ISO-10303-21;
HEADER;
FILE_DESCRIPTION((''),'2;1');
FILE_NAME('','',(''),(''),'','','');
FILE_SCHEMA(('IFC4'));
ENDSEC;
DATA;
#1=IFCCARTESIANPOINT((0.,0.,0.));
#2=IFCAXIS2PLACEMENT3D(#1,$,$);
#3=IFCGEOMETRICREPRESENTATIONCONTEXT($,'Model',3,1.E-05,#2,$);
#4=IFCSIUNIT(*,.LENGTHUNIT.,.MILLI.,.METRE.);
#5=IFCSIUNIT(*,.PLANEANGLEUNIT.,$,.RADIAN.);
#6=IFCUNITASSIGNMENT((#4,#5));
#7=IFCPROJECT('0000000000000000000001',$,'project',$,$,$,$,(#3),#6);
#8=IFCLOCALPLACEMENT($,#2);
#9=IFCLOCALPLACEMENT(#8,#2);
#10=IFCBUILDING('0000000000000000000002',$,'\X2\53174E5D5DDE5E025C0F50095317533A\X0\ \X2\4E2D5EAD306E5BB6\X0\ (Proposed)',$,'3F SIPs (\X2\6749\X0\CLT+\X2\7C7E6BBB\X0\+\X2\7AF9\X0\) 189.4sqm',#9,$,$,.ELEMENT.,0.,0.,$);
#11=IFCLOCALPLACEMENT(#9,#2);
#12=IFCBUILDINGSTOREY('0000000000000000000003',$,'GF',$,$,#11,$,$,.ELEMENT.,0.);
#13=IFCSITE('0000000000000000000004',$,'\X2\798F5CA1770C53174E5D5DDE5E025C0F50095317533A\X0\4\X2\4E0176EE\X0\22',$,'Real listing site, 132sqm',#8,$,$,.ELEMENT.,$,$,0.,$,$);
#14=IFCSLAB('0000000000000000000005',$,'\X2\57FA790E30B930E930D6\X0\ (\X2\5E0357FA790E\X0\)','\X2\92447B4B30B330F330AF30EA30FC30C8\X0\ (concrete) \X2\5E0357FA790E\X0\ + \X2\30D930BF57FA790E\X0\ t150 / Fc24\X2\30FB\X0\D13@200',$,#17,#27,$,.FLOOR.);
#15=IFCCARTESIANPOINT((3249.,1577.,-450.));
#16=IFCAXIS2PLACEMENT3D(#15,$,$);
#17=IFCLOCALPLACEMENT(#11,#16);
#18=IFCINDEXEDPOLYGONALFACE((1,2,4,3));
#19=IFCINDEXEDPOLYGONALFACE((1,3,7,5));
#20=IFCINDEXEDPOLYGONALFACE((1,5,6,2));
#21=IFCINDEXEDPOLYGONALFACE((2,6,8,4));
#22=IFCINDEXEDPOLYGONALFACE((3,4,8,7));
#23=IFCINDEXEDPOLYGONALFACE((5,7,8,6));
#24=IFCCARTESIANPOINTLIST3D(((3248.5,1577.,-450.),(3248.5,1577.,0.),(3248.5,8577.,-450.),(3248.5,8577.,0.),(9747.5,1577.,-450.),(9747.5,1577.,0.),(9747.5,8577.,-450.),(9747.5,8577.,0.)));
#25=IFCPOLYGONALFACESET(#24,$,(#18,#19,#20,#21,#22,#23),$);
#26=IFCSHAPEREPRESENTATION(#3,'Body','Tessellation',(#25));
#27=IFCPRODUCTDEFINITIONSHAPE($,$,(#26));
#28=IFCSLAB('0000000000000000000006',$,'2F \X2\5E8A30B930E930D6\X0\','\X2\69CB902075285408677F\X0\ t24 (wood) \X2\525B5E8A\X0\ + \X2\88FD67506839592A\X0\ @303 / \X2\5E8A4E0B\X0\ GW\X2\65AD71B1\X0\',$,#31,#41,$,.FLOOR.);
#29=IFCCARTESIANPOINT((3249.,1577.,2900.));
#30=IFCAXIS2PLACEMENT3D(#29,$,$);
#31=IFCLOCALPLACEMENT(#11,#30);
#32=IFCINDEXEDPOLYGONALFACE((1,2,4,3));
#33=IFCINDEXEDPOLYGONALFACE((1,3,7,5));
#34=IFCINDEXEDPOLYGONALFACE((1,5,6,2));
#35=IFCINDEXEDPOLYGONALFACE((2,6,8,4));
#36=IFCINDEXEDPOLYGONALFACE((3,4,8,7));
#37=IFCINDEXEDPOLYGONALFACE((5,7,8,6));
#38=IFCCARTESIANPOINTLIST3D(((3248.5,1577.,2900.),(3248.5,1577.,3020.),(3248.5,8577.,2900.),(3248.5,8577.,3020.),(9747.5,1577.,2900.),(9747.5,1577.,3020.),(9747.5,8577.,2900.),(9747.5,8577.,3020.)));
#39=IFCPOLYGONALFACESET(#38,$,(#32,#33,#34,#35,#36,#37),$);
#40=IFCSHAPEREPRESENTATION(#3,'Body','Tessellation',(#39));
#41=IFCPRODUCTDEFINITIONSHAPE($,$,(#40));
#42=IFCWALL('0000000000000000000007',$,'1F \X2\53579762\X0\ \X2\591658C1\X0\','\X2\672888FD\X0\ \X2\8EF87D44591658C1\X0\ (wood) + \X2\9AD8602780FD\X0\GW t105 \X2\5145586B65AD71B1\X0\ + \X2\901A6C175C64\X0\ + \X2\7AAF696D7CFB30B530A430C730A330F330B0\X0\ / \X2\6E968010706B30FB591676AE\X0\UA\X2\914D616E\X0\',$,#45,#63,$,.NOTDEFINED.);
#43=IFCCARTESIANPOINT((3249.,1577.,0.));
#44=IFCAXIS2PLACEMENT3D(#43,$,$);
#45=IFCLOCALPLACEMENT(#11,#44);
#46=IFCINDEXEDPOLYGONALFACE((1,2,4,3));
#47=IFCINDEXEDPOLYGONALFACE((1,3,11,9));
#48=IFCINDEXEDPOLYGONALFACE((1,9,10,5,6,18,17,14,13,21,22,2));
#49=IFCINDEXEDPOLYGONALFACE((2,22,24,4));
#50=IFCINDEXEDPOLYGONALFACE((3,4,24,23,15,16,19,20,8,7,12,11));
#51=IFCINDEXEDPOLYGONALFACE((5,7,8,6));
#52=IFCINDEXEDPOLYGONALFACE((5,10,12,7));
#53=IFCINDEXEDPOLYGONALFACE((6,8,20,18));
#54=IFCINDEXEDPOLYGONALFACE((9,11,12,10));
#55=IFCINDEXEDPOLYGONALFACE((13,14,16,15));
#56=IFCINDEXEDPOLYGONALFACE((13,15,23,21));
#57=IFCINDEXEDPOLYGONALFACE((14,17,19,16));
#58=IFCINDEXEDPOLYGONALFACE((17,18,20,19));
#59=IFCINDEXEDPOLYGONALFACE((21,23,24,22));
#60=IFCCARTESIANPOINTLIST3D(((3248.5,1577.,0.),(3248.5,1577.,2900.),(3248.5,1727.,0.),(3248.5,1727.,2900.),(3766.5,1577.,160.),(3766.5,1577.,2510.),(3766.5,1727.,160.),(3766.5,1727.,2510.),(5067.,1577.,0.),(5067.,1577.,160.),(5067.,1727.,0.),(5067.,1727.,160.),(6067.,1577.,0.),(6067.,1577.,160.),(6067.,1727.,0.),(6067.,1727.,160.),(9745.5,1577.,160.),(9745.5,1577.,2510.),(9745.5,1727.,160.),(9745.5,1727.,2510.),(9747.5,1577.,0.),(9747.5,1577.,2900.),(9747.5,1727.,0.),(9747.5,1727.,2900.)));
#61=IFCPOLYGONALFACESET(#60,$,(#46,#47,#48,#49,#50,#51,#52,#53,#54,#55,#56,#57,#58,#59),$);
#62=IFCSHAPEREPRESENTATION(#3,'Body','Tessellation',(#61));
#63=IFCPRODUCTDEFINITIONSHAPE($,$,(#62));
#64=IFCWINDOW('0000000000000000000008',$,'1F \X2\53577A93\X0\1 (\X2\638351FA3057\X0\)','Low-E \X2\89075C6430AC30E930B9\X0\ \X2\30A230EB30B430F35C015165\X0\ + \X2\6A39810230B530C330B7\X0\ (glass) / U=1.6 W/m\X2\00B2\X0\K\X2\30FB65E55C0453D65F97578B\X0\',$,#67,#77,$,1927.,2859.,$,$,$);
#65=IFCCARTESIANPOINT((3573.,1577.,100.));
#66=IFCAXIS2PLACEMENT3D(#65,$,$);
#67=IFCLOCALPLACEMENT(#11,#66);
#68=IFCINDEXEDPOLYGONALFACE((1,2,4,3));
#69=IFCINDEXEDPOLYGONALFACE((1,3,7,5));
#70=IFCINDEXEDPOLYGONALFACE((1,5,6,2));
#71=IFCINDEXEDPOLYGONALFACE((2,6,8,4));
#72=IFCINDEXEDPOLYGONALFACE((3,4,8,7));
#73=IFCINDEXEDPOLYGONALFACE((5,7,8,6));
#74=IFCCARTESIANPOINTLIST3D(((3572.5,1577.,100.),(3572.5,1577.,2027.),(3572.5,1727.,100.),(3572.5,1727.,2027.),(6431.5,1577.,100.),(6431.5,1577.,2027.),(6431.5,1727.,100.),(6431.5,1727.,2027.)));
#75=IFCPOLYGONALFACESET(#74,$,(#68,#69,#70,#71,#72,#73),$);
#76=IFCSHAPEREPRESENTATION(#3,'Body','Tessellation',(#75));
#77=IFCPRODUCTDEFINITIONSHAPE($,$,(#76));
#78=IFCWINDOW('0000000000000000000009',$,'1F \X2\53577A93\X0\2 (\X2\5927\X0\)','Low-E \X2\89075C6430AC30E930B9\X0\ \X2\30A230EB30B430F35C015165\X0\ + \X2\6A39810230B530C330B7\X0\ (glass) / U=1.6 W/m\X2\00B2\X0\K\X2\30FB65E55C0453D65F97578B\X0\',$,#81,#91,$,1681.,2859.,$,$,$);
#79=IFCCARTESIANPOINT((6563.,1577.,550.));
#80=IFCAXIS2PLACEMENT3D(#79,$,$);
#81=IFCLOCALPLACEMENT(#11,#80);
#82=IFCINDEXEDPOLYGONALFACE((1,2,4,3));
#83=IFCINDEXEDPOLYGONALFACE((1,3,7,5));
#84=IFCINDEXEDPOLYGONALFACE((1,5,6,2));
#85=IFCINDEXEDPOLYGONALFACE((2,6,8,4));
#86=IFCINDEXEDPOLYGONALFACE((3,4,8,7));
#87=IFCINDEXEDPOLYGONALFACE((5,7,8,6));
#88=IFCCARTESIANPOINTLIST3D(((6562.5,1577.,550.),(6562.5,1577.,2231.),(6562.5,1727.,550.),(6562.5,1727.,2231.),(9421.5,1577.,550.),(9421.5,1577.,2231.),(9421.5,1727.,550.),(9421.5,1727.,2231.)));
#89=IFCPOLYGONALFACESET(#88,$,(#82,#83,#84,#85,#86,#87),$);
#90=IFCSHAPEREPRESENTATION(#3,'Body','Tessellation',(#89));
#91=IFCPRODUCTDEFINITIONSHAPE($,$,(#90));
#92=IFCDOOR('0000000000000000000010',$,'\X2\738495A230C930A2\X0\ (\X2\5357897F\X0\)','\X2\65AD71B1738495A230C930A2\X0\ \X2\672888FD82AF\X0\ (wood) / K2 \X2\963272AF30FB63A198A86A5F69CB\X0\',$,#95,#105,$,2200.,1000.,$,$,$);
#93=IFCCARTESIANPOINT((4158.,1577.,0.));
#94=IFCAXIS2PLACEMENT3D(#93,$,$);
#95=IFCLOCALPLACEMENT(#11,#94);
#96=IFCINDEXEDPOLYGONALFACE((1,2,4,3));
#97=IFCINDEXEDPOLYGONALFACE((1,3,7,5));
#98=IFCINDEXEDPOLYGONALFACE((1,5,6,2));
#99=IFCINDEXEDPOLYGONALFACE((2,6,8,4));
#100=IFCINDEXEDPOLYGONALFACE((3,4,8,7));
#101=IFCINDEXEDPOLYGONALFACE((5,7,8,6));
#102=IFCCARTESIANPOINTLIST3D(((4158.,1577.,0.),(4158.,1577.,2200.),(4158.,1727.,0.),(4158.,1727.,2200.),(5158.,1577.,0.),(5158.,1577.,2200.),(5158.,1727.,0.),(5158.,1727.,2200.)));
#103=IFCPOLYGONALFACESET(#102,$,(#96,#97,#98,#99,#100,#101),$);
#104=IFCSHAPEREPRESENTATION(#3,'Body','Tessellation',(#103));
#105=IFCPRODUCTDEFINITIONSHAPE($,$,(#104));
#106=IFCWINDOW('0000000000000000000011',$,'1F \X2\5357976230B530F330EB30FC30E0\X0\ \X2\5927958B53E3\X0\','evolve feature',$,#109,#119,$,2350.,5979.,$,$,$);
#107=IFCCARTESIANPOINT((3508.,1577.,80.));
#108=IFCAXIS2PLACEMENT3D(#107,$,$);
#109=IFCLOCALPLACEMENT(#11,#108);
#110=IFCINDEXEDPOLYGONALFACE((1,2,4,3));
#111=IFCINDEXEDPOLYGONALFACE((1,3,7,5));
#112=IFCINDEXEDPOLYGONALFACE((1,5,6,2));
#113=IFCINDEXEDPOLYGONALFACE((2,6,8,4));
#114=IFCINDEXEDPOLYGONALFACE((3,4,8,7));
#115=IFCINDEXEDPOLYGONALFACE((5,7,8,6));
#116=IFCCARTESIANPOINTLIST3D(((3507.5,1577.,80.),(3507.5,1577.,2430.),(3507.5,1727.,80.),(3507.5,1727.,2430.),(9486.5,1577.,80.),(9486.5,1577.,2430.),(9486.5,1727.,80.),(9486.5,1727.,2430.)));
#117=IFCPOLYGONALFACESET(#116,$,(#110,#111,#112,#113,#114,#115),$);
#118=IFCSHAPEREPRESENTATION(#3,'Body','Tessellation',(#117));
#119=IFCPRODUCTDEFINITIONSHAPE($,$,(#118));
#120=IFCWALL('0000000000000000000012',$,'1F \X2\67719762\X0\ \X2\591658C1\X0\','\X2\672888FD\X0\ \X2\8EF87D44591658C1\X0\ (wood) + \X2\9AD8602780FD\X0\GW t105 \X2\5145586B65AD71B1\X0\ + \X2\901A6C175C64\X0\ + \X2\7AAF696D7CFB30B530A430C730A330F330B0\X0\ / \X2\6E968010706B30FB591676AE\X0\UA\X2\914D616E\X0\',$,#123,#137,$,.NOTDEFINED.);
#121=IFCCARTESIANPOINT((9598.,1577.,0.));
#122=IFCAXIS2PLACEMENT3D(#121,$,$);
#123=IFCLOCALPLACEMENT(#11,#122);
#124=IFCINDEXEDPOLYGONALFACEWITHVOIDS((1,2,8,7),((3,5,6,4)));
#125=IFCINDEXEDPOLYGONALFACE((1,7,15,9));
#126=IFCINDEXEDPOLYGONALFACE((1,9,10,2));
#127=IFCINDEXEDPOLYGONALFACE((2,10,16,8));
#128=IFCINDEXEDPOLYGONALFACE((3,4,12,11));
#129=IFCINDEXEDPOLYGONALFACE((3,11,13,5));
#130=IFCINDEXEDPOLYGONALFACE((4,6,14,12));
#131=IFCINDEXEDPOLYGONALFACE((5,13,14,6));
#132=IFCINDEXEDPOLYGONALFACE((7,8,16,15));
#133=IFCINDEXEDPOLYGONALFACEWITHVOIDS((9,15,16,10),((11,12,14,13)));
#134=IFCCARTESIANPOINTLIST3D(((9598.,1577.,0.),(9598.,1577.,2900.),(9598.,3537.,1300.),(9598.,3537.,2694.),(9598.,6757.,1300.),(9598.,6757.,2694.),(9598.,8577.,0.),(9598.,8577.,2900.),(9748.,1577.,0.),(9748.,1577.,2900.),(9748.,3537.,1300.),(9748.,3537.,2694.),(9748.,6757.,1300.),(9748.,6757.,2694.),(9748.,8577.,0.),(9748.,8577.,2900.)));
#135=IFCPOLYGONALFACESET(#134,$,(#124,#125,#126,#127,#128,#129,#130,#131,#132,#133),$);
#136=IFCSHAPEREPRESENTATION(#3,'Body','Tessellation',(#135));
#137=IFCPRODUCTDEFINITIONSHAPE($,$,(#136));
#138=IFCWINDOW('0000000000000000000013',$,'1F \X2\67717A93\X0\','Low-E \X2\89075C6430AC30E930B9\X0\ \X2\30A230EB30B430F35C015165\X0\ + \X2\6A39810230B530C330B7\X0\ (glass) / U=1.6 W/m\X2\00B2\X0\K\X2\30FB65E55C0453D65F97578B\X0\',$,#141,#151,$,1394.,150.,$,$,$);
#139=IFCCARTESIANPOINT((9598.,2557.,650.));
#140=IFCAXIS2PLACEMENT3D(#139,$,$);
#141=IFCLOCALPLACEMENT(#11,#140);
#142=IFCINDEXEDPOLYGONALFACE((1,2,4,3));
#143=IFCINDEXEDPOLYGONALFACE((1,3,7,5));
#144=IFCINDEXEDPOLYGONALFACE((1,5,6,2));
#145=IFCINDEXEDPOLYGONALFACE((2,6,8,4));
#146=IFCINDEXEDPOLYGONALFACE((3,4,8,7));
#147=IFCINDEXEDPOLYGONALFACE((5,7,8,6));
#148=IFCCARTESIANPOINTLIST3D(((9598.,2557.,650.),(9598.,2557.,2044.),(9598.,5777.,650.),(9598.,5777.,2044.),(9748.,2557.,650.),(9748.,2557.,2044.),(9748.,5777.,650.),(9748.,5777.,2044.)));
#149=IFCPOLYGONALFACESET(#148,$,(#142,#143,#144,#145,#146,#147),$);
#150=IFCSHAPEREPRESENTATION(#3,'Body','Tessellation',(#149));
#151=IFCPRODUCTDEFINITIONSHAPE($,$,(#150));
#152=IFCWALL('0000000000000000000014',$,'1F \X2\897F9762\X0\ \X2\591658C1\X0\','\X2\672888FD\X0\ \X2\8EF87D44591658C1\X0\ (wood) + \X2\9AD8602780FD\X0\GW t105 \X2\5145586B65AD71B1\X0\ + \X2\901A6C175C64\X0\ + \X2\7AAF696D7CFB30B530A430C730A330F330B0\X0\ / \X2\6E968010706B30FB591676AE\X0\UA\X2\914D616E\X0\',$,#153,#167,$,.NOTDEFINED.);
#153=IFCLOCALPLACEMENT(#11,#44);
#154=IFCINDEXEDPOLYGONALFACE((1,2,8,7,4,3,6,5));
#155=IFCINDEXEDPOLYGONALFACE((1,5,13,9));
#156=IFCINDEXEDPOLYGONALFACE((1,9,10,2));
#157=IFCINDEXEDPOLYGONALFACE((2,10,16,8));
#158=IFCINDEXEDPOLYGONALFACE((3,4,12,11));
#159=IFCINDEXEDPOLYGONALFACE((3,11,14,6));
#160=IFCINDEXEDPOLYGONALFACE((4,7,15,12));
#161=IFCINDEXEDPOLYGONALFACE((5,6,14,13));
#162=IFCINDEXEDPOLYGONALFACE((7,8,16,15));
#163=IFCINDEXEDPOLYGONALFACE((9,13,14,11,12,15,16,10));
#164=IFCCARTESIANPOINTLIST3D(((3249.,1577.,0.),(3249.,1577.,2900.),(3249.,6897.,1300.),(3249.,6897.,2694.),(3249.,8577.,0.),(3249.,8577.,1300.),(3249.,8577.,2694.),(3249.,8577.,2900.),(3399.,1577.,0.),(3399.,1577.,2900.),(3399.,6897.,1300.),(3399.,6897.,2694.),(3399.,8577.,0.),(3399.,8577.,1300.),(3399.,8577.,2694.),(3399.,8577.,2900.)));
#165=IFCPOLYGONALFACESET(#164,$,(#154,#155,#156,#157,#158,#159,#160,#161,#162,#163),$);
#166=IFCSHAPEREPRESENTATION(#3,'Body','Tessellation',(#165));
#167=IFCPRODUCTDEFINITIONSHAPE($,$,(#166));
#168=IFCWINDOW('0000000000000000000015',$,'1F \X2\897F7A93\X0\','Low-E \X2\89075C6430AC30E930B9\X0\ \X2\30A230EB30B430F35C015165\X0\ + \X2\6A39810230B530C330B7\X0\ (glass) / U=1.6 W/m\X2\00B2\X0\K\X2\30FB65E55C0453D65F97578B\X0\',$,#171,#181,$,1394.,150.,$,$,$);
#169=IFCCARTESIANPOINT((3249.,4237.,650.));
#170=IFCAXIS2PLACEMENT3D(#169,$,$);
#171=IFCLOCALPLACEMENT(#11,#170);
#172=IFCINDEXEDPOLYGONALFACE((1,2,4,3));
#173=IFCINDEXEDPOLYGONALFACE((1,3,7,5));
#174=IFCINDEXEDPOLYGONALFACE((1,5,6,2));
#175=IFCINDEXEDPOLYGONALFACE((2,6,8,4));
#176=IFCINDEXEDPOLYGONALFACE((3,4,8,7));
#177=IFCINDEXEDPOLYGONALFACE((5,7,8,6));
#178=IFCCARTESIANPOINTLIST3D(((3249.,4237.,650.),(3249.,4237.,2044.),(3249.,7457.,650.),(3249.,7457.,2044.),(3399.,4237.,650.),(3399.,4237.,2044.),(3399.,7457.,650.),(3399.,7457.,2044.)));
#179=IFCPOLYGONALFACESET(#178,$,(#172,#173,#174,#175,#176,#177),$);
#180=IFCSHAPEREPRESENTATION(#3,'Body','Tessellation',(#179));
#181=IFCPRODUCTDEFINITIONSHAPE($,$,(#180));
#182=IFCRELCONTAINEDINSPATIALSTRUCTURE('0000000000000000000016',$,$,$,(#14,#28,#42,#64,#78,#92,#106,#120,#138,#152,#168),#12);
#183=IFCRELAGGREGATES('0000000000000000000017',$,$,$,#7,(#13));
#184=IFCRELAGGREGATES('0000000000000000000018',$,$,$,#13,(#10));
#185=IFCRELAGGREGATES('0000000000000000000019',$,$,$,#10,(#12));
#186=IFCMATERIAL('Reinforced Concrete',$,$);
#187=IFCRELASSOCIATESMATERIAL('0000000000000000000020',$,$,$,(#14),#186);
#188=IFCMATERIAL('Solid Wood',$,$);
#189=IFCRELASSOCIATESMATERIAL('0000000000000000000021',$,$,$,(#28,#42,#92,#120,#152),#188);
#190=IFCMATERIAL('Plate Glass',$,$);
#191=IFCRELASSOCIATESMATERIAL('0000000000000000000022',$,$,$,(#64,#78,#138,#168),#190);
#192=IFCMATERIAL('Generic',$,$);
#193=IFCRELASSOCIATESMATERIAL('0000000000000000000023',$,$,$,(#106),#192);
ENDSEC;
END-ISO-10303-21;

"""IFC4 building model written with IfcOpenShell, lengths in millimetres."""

from ifc_helpers import new_model, si_unit, frame, frame_2d, origin, place, context, project, spatial, rectangle, extrude, material, element, fill, save


model = new_model("IFC4")

# Units and contexts
model_context = context("Model", 3, precision=1e-05, world=origin())
ifc_project = project(units=[si_unit("LENGTHUNIT", "METRE", prefix="MILLI"), si_unit("PLANEANGLEUNIT", "RADIAN")], contexts=[model_context])

# Site, building, storey
site_placement = place(None, origin())
site = spatial("IfcSite", under=ifc_project, at=site_placement, Name="福岡県北九州市小倉北区4丁目22", ObjectType="Real listing site, 132sqm", CompositionType="ELEMENT", RefElevation=0.0)
building_placement = place(site_placement, origin())
building = spatial("IfcBuilding", under=site, at=building_placement, Name="北九州市小倉北区 中庭の家 (Proposed)", ObjectType="3F SIPs (杉CLT+籾殻+竹) 189.4sqm", CompositionType="ELEMENT", ElevationOfRefHeight=0.0, ElevationOfTerrain=0.0)
storey_placement = place(building_placement, origin())
storey = spatial("IfcBuildingStorey", under=building, at=storey_placement, Name="GF", CompositionType="ELEMENT", Elevation=0.0)

# Slabs
ifc_material_1 = material(Name="Reinforced Concrete")
slab_1_placement = place(storey_placement, frame((3249.0, 1577.0, -450.0)))
element("IfcSlab", 1, at=slab_1_placement, inside=storey, material=ifc_material_1, Name="基礎スラブ (布基礎)", Description="鉄筋コンクリート (concrete) 布基礎 + ベタ基礎 t150 / Fc24・D13@200", PredefinedType="FLOOR", context=model_context, shape_type="SweptSolid", body=[
    extrude(rectangle(XDim=6499.0, YDim=7000.0, at=frame_2d((3249.0, 3500.0))), frame((3249.0, 1577.0, -450.0)), (0.0, 0.0, 1.0), 450.0),
])
ifc_material_2 = material(Name="Solid Wood")
slab_2_placement = place(storey_placement, frame((3249.0, 1577.0, 2900.0)))
element("IfcSlab", 2, at=slab_2_placement, inside=storey, material=ifc_material_2, Name="2F 床スラブ", Description="構造用合板 t24 (wood) 剛床 + 製材根太 @303 / 床下 GW断熱", PredefinedType="FLOOR", context=model_context, shape_type="SweptSolid", body=[
    extrude(rectangle(XDim=6499.0, YDim=7000.0, at=frame_2d((3249.0, 3500.0))), frame((3249.0, 1577.0, 2900.0)), (0.0, 0.0, 1.0), 120.0),
])

# Wall, openings, windows, door
wall_1_placement = place(storey_placement, frame((3249.0, 1577.0, 0.0)))
wall_1 = element("IfcWall", 3, at=wall_1_placement, inside=storey, material=ifc_material_2, Name="1F 南面 外壁", Description="木製 軸組外壁 (wood) + 高性能GW t105 充填断熱 + 通気層 + 窯業系サイディング / 準耐火・外皮UA配慮", PredefinedType="NOTDEFINED", context=model_context, shape_type="SweptSolid", body=[
    extrude(rectangle(XDim=6499.0, YDim=150.0, at=frame_2d((3249.0, 75.0))), frame((3249.0, 1577.0, 0.0)), (0.0, 0.0, 1.0), 2900.0),
])
opening_1_placement = place(storey_placement, frame((3573.0, 1577.0, 100.0)))
opening_1 = element("IfcOpeningElement", 4, at=opening_1_placement, cuts=wall_1, PredefinedType="NOTDEFINED", context=model_context, shape_type="SweptSolid", body=[
    extrude(rectangle(XDim=2859.0, YDim=150.0, at=frame_2d((1429.0, 75.0))), frame((3573.0, 1577.0, 100.0)), (0.0, 0.0, 1.0), 1927.0),
])
opening_2_placement = place(storey_placement, frame((6563.0, 1577.0, 550.0)))
opening_2 = element("IfcOpeningElement", 5, at=opening_2_placement, cuts=wall_1, PredefinedType="NOTDEFINED", context=model_context, shape_type="SweptSolid", body=[
    extrude(rectangle(XDim=2859.0, YDim=150.0, at=frame_2d((1429.0, 75.0))), frame((6563.0, 1577.0, 550.0)), (0.0, 0.0, 1.0), 1681.0),
])
opening_3_placement = place(storey_placement, frame((4158.0, 1577.0, 0.0)))
opening_3 = element("IfcOpeningElement", 6, at=opening_3_placement, cuts=wall_1, PredefinedType="NOTDEFINED", context=model_context, shape_type="SweptSolid", body=[
    extrude(rectangle(XDim=1000.0, YDim=150.0, at=frame_2d((500.0, 75.0))), frame((4158.0, 1577.0, 0.0)), (0.0, 0.0, 1.0), 2200.0),
])
opening_4_placement = place(storey_placement, frame((3508.0, 1577.0, 80.0)))
opening_4 = element("IfcOpeningElement", 7, at=opening_4_placement, cuts=wall_1, PredefinedType="NOTDEFINED", context=model_context, shape_type="SweptSolid", body=[
    extrude(rectangle(XDim=5979.0, YDim=150.0, at=frame_2d((2989.0, 75.0))), frame((3508.0, 1577.0, 80.0)), (0.0, 0.0, 1.0), 2350.0),
])
ifc_material_3 = material(Name="Plate Glass")
window_1_placement = place(storey_placement, frame((3573.0, 1577.0, 100.0)))
window_1 = element("IfcWindow", 8, at=window_1_placement, inside=storey, material=ifc_material_3, Name="1F 南窓1 (掃出し)", Description="Low-E 複層ガラス アルゴン封入 + 樹脂サッシ (glass) / U=1.6 W/m²K・日射取得型", OverallHeight=1927.0, OverallWidth=2859.0, context=model_context, shape_type="SweptSolid", body=[
    extrude(rectangle(XDim=2859.0, YDim=150.0, at=frame_2d((1429.0, 75.0))), frame((3573.0, 1577.0, 100.0)), (0.0, 0.0, 1.0), 1927.0),
])
fill(opening_1, window_1)
window_2_placement = place(storey_placement, frame((6563.0, 1577.0, 550.0)))
window_2 = element("IfcWindow", 9, at=window_2_placement, inside=storey, material=ifc_material_3, Name="1F 南窓2 (大)", Description="Low-E 複層ガラス アルゴン封入 + 樹脂サッシ (glass) / U=1.6 W/m²K・日射取得型", OverallHeight=1681.0, OverallWidth=2859.0, context=model_context, shape_type="SweptSolid", body=[
    extrude(rectangle(XDim=2859.0, YDim=150.0, at=frame_2d((1429.0, 75.0))), frame((6563.0, 1577.0, 550.0)), (0.0, 0.0, 1.0), 1681.0),
])
fill(opening_2, window_2)
door_placement = place(storey_placement, frame((4158.0, 1577.0, 0.0)))
door = element("IfcDoor", 10, at=door_placement, inside=storey, material=ifc_material_2, Name="玄関ドア (南西)", Description="断熱玄関ドア 木製芯 (wood) / K2 防犯・採風機構", OverallHeight=2200.0, OverallWidth=1000.0, context=model_context, shape_type="SweptSolid", body=[
    extrude(rectangle(XDim=1000.0, YDim=150.0, at=frame_2d((500.0, 75.0))), frame((4158.0, 1577.0, 0.0)), (0.0, 0.0, 1.0), 2200.0),
])
fill(opening_3, door)
ifc_material_4 = material(Name="Generic")
window_3_placement = place(storey_placement, frame((3508.0, 1577.0, 80.0)))
window_3 = element("IfcWindow", 11, at=window_3_placement, inside=storey, material=ifc_material_4, Name="1F 南面サンルーム 大開口", Description="evolve feature", OverallHeight=2350.0, OverallWidth=5979.0, context=model_context, shape_type="SweptSolid", body=[
    extrude(rectangle(XDim=5979.0, YDim=150.0, at=frame_2d((2989.0, 75.0))), frame((3508.0, 1577.0, 80.0)), (0.0, 0.0, 1.0), 2350.0),
])
fill(opening_4, window_3)

# Walls, openings, windows
wall_2_placement = place(storey_placement, frame((9598.0, 1577.0, 0.0)))
wall_2 = element("IfcWall", 12, at=wall_2_placement, inside=storey, material=ifc_material_2, Name="1F 東面 外壁", Description="木製 軸組外壁 (wood) + 高性能GW t105 充填断熱 + 通気層 + 窯業系サイディング / 準耐火・外皮UA配慮", PredefinedType="NOTDEFINED", context=model_context, shape_type="SweptSolid", body=[
    extrude(rectangle(XDim=150.0, YDim=7000.0, at=frame_2d((75.0, 3500.0))), frame((9598.0, 1577.0, 0.0)), (0.0, 0.0, 1.0), 2900.0),
])
opening_5_placement = place(storey_placement, frame((9598.0, 2557.0, 650.0)))
opening_5 = element("IfcOpeningElement", 13, at=opening_5_placement, cuts=wall_2, PredefinedType="NOTDEFINED", context=model_context, shape_type="SweptSolid", body=[
    extrude(rectangle(XDim=150.0, YDim=3220.0, at=frame_2d((75.0, 1610.0))), frame((9598.0, 2557.0, 650.0)), (0.0, 0.0, 1.0), 1394.0),
])
window_4_placement = place(storey_placement, frame((9598.0, 2557.0, 650.0)))
window_4 = element("IfcWindow", 14, at=window_4_placement, inside=storey, material=ifc_material_3, Name="1F 東窓", Description="Low-E 複層ガラス アルゴン封入 + 樹脂サッシ (glass) / U=1.6 W/m²K・日射取得型", OverallHeight=1394.0, OverallWidth=150.0, context=model_context, shape_type="SweptSolid", body=[
    extrude(rectangle(XDim=150.0, YDim=3220.0, at=frame_2d((75.0, 1610.0))), frame((9598.0, 2557.0, 650.0)), (0.0, 0.0, 1.0), 1394.0),
])
fill(opening_5, window_4)
wall_3_placement = place(storey_placement, frame((3249.0, 1577.0, 0.0)))
wall_3 = element("IfcWall", 15, at=wall_3_placement, inside=storey, material=ifc_material_2, Name="1F 西面 外壁", Description="木製 軸組外壁 (wood) + 高性能GW t105 充填断熱 + 通気層 + 窯業系サイディング / 準耐火・外皮UA配慮", PredefinedType="NOTDEFINED", context=model_context, shape_type="SweptSolid", body=[
    extrude(rectangle(XDim=150.0, YDim=7000.0, at=frame_2d((75.0, 3500.0))), frame((3249.0, 1577.0, 0.0)), (0.0, 0.0, 1.0), 2900.0),
])
opening_6_placement = place(storey_placement, frame((3249.0, 4237.0, 650.0)))
opening_6 = element("IfcOpeningElement", 16, at=opening_6_placement, cuts=wall_3, PredefinedType="NOTDEFINED", context=model_context, shape_type="SweptSolid", body=[
    extrude(rectangle(XDim=150.0, YDim=3220.0, at=frame_2d((75.0, 1610.0))), frame((3249.0, 4237.0, 650.0)), (0.0, 0.0, 1.0), 1394.0),
])
window_5_placement = place(storey_placement, frame((3249.0, 4237.0, 650.0)))
window_5 = element("IfcWindow", 17, at=window_5_placement, inside=storey, material=ifc_material_3, Name="1F 西窓", Description="Low-E 複層ガラス アルゴン封入 + 樹脂サッシ (glass) / U=1.6 W/m²K・日射取得型", OverallHeight=1394.0, OverallWidth=150.0, context=model_context, shape_type="SweptSolid", body=[
    extrude(rectangle(XDim=150.0, YDim=3220.0, at=frame_2d((75.0, 1610.0))), frame((3249.0, 4237.0, 650.0)), (0.0, 0.0, 1.0), 1394.0),
])
fill(opening_6, window_5)

save(model, "model.ifc")
